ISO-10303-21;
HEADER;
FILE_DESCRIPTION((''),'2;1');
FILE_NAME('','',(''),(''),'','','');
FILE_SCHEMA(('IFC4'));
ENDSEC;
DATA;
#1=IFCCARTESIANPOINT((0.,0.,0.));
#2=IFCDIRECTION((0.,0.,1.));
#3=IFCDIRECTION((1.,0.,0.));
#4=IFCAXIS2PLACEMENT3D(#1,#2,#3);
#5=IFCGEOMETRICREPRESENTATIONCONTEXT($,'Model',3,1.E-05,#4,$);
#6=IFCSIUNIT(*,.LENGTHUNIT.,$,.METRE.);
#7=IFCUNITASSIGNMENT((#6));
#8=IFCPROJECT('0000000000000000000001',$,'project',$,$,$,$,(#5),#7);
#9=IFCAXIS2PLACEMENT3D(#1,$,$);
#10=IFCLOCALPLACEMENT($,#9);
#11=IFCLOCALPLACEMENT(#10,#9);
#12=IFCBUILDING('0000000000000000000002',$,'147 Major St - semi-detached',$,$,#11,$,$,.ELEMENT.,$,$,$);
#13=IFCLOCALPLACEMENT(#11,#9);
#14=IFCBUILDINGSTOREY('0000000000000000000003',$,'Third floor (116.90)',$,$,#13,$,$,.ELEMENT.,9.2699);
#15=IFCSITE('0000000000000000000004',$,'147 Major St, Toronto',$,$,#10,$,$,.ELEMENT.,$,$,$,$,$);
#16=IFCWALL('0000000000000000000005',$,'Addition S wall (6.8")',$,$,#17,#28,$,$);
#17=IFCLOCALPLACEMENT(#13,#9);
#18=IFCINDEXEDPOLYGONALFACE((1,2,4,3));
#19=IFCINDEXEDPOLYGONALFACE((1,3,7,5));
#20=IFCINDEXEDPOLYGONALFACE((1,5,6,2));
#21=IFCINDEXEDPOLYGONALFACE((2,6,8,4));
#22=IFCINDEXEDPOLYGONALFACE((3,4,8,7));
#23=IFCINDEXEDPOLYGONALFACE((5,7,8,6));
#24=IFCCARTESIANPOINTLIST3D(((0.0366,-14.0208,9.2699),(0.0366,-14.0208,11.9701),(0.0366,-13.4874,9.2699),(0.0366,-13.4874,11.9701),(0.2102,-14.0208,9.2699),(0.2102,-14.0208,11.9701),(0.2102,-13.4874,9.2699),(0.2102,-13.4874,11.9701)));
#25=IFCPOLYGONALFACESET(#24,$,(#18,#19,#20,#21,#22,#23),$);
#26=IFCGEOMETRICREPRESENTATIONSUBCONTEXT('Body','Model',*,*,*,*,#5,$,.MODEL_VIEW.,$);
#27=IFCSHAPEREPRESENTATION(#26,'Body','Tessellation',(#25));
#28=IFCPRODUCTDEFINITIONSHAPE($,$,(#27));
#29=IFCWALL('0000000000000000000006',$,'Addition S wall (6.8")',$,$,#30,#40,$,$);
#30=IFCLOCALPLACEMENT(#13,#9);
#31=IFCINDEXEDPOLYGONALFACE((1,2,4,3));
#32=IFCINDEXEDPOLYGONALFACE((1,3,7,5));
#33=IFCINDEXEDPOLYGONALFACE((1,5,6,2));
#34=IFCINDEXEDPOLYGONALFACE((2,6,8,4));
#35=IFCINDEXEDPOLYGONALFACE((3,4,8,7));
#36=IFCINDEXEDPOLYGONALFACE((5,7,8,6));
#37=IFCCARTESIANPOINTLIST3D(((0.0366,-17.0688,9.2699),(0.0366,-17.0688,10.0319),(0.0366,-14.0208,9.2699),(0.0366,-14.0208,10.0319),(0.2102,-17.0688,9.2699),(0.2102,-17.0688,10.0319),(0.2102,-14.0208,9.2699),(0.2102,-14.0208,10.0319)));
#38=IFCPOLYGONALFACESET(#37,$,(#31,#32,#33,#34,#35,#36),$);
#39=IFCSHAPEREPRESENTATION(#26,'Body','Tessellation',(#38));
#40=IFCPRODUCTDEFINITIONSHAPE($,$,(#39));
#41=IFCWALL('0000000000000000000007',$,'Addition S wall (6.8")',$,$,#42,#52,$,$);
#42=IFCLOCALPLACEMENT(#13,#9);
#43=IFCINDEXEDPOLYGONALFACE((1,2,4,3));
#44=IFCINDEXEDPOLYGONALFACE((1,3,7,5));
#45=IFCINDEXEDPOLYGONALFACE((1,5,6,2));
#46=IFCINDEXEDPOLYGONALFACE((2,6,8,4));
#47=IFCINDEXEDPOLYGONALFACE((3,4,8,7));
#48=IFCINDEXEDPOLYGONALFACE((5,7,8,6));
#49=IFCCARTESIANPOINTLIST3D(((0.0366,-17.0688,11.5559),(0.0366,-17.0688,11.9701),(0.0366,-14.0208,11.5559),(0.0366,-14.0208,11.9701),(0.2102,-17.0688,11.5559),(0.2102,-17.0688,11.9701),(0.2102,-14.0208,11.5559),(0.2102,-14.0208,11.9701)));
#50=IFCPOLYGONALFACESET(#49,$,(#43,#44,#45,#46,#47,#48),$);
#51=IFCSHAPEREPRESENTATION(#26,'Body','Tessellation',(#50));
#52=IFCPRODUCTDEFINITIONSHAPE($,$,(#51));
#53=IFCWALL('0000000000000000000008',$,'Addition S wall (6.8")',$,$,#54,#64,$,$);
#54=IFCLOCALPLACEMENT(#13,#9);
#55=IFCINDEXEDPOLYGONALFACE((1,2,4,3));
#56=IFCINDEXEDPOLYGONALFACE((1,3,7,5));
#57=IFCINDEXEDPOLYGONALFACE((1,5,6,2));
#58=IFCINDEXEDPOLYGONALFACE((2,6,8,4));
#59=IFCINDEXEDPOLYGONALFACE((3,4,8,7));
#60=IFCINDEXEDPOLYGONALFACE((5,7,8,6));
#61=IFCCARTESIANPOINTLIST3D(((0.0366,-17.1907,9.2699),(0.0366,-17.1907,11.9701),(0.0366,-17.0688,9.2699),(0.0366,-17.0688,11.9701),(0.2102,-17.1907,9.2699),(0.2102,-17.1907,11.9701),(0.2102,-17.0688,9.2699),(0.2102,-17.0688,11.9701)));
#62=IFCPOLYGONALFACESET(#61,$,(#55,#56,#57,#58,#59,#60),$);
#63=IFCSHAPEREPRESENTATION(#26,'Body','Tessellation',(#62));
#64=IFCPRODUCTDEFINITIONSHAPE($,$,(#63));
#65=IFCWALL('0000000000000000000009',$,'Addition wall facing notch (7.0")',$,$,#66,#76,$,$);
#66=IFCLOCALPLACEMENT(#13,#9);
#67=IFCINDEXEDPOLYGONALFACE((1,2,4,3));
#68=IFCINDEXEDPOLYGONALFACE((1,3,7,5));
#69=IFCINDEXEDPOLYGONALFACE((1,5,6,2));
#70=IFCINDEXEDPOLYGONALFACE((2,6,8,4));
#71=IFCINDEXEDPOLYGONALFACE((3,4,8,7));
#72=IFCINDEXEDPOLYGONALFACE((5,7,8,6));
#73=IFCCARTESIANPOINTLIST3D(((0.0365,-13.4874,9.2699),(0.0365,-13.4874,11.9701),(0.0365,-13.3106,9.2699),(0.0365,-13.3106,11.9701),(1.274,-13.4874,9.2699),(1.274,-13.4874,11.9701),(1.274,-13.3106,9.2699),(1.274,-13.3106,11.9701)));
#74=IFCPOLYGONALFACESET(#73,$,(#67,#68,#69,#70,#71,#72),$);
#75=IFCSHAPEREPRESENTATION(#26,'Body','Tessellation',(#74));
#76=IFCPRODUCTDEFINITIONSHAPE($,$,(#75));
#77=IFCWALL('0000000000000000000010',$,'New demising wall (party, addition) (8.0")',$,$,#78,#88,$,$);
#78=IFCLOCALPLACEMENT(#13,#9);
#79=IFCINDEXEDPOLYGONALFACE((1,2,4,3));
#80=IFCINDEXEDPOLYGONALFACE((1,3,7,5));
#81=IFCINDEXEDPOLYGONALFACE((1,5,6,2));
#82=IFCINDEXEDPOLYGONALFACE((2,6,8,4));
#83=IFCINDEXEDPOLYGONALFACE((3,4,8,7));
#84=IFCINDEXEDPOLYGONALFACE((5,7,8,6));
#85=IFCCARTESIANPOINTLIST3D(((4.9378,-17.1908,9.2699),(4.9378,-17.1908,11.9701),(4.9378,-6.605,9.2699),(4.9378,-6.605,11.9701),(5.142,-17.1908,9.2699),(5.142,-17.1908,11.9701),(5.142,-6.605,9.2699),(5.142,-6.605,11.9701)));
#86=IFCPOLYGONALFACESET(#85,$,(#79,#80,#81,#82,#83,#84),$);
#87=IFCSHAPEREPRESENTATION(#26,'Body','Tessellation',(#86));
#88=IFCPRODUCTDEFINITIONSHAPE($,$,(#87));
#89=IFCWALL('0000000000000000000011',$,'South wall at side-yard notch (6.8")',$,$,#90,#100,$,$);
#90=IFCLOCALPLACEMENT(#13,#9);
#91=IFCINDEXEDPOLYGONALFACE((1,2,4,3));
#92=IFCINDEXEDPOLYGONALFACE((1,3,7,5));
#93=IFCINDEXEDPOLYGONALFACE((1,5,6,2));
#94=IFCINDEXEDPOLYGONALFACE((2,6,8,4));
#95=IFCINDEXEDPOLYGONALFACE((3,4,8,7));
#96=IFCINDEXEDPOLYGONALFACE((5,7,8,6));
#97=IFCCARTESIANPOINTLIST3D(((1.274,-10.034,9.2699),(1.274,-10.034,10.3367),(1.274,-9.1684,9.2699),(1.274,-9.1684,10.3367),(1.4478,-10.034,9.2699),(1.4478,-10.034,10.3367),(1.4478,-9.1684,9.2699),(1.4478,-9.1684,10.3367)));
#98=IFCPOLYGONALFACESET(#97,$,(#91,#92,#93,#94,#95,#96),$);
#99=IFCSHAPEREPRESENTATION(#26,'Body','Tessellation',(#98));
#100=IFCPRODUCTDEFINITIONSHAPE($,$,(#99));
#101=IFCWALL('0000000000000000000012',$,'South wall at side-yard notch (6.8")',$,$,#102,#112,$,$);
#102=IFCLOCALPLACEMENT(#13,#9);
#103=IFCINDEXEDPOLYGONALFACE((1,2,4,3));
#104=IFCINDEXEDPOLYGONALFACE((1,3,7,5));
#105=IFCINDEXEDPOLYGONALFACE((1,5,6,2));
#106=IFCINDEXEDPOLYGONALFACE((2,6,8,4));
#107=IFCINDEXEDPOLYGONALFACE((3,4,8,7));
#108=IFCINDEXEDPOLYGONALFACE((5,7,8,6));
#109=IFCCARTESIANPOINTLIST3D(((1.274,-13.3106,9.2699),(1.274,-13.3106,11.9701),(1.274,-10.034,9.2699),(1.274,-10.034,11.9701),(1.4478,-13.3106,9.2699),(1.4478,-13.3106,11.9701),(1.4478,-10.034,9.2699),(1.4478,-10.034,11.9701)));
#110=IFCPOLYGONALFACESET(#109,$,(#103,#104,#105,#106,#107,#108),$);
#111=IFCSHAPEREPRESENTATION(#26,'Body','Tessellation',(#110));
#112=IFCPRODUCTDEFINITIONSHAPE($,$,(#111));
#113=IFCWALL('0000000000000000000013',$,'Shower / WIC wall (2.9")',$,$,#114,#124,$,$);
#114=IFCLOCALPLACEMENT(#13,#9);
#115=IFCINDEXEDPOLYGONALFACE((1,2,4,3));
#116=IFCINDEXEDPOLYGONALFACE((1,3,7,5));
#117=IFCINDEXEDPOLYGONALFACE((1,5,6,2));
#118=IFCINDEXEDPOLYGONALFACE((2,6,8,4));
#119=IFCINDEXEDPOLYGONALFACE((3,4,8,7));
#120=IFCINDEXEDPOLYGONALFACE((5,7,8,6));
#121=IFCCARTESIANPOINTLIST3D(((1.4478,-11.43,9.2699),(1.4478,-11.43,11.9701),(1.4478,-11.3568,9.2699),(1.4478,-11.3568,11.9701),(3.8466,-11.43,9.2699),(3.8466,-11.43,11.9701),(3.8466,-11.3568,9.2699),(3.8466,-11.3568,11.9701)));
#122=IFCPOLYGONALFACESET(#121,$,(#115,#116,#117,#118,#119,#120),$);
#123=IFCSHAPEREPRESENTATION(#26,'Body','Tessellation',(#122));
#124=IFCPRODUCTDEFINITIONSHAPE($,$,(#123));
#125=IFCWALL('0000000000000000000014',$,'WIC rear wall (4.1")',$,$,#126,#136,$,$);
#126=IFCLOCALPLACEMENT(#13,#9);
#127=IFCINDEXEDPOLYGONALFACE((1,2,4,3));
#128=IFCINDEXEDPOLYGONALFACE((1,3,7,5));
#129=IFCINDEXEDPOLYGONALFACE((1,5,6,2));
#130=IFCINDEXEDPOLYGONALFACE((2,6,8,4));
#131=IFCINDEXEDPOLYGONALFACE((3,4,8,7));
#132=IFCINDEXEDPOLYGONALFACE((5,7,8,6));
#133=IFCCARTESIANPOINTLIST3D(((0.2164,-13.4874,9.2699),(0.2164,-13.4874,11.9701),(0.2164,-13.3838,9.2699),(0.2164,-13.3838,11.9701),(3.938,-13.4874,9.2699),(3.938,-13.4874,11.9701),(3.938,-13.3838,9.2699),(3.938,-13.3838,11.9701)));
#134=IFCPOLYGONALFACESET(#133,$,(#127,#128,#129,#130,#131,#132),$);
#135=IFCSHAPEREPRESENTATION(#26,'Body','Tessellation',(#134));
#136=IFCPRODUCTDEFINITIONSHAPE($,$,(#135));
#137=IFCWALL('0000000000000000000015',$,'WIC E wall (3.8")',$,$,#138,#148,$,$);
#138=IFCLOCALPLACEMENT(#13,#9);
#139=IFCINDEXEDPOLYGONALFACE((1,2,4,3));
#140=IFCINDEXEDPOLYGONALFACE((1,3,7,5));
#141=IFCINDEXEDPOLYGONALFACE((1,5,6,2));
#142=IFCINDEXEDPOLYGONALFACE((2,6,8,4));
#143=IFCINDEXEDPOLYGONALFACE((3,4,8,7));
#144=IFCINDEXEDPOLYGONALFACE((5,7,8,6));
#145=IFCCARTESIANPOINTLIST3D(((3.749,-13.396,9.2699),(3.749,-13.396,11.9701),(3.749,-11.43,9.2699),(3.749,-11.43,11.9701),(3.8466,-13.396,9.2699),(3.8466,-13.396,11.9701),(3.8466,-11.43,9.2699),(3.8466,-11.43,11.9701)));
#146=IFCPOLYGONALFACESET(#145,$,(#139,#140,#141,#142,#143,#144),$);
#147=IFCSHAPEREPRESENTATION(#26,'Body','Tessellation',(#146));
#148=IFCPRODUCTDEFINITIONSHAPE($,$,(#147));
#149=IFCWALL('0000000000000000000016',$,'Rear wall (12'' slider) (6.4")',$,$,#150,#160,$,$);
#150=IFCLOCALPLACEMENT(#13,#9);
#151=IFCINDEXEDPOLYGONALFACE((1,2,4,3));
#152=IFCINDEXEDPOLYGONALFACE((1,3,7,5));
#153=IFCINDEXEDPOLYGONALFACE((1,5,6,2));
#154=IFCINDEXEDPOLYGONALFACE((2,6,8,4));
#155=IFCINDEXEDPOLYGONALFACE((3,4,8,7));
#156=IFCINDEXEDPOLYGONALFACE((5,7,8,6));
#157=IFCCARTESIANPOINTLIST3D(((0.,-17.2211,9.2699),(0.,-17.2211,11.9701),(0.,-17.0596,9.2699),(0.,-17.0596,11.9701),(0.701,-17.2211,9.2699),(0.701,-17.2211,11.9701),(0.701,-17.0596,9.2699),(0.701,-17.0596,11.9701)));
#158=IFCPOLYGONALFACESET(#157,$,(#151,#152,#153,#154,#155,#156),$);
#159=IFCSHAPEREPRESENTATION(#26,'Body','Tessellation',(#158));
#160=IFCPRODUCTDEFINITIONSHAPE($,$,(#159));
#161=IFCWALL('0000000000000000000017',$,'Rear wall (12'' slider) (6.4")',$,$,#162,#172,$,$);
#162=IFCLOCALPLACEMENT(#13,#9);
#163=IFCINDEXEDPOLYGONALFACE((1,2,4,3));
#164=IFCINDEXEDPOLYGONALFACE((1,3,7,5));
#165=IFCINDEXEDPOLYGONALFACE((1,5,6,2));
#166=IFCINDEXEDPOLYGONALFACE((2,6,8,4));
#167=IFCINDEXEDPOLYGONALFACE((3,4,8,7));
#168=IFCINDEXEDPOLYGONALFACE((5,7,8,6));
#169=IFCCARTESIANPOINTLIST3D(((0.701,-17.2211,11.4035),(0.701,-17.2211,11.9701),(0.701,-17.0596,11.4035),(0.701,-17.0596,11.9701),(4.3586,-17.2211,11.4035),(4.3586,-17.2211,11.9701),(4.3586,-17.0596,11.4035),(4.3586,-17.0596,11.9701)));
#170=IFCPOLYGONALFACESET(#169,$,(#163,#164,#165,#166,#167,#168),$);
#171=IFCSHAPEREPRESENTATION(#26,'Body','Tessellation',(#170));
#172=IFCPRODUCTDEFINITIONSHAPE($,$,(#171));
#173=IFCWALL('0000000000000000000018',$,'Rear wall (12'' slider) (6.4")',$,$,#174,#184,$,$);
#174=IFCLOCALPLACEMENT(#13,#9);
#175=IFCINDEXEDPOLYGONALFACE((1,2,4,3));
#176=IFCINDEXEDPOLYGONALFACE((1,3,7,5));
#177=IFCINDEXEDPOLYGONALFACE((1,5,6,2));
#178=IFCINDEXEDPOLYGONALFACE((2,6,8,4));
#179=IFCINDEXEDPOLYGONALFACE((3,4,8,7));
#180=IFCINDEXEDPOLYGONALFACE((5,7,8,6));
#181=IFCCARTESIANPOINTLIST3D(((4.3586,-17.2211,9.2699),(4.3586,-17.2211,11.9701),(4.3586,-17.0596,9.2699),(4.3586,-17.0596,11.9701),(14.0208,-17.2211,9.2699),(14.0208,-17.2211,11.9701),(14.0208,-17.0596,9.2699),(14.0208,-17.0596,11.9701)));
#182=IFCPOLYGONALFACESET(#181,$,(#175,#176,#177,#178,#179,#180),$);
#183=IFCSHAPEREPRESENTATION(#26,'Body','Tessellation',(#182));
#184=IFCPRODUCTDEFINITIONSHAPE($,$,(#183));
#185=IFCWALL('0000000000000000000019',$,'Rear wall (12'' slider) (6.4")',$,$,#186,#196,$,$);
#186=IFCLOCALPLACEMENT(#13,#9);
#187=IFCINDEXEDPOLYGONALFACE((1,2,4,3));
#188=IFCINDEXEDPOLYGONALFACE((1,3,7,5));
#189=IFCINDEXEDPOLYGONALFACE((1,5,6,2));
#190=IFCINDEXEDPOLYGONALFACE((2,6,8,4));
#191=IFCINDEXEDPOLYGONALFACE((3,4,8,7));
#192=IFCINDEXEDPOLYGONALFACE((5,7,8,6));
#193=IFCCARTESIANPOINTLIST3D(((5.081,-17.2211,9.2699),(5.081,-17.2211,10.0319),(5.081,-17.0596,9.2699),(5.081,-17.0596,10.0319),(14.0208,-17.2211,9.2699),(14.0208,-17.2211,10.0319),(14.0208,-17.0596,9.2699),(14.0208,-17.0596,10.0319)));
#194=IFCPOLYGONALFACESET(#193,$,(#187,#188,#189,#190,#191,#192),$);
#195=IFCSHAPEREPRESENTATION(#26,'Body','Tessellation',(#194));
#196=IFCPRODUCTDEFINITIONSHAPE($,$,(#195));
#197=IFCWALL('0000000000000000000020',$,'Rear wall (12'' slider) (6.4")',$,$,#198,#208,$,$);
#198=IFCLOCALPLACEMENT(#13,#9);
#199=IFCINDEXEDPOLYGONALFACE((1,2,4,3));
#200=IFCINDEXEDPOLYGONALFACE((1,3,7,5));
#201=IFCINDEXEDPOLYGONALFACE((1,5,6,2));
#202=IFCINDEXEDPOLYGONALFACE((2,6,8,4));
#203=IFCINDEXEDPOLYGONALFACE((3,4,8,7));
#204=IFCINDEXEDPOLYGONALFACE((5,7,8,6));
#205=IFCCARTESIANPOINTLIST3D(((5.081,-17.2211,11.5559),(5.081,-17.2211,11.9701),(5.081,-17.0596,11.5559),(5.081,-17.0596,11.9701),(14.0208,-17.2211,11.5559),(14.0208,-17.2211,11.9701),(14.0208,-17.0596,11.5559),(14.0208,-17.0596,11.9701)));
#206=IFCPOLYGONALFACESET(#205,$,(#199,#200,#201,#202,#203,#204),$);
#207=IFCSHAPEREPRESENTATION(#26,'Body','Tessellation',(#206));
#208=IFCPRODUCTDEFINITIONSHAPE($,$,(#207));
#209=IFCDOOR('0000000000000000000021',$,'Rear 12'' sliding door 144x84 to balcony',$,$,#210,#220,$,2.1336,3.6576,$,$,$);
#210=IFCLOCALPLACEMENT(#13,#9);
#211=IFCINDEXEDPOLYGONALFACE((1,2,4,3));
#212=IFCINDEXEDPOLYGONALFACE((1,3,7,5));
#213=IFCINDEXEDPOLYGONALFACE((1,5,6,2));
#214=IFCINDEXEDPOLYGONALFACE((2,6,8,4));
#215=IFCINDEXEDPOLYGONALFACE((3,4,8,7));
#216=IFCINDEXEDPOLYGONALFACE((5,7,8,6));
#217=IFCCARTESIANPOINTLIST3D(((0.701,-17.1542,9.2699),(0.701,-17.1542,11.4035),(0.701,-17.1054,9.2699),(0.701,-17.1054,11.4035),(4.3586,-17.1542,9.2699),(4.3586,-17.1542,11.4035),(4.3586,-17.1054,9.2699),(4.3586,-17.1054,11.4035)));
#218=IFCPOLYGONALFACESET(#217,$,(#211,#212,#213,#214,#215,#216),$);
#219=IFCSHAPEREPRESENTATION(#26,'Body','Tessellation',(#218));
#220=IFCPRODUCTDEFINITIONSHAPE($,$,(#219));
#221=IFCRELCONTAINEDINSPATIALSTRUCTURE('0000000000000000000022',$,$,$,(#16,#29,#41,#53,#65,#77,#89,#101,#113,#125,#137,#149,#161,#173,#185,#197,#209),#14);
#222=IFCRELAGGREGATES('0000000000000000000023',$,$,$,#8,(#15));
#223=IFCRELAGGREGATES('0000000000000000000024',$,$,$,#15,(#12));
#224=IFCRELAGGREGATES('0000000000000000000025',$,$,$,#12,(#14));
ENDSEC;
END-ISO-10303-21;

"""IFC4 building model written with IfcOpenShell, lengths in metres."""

from ifc_helpers import new_model, si_unit, frame, origin, origin_with_axes, place, context, subcontext, project, spatial, rectangle, extrude, element, save


model = new_model("IFC4")

# Units and contexts
model_context = context("Model", 3, precision=1e-05, world=origin_with_axes())
body_context = subcontext(model_context, "Body", "Model", "MODEL_VIEW")
ifc_project = project(units=[si_unit("LENGTHUNIT", "METRE")], contexts=[model_context])

# Site, building, storey
site_placement = place(None, origin())
site = spatial("IfcSite", under=ifc_project, at=site_placement, Name="147 Major St, Toronto", CompositionType="ELEMENT")
building_placement = place(site_placement, origin())
building = spatial("IfcBuilding", under=site, at=building_placement, Name="147 Major St - semi-detached", CompositionType="ELEMENT")
storey_placement = place(building_placement, origin())
storey = spatial("IfcBuildingStorey", under=building, at=storey_placement, Name="Third floor (116.90)", CompositionType="ELEMENT", Elevation=9.2699)

# Walls
wall_1_placement = place(storey_placement, frame((0.1234, -13.7541, 9.2699)))
element("IfcWall", 1, at=wall_1_placement, inside=storey, Name="Addition S wall (6.8\")", context=body_context, shape_type="SweptSolid", body=[
    extrude(rectangle(XDim=0.1737, YDim=0.5334), origin_with_axes(), (0.0, 0.0, 1.0), 2.7002),
])
wall_2_placement = place(storey_placement, frame((0.1234, -15.5448, 9.2699)))
element("IfcWall", 2, at=wall_2_placement, inside=storey, Name="Addition S wall (6.8\")", context=body_context, shape_type="SweptSolid", body=[
    extrude(rectangle(XDim=0.1737, YDim=3.048), origin_with_axes(), (0.0, 0.0, 1.0), 0.762),
])
wall_3_placement = place(storey_placement, frame((0.1234, -15.5448, 11.5559)))
element("IfcWall", 3, at=wall_3_placement, inside=storey, Name="Addition S wall (6.8\")", context=body_context, shape_type="SweptSolid", body=[
    extrude(rectangle(XDim=0.1737, YDim=3.048), origin_with_axes(), (0.0, 0.0, 1.0), 0.4142),
])
wall_4_placement = place(storey_placement, frame((0.1234, -17.1298, 9.2699)))
element("IfcWall", 4, at=wall_4_placement, inside=storey, Name="Addition S wall (6.8\")", context=body_context, shape_type="SweptSolid", body=[
    extrude(rectangle(XDim=0.1737, YDim=0.1219), origin_with_axes(), (0.0, 0.0, 1.0), 2.7002),
])
wall_5_placement = place(storey_placement, frame((0.6553, -13.399, 9.2699)))
element("IfcWall", 5, at=wall_5_placement, inside=storey, Name="Addition wall facing notch (7.0\")", context=body_context, shape_type="SweptSolid", body=[
    extrude(rectangle(XDim=1.2375, YDim=0.1768), origin_with_axes(), (0.0, 0.0, 1.0), 2.7002),
])
wall_6_placement = place(storey_placement, frame((5.0399, -11.8979, 9.2699)))
element("IfcWall", 6, at=wall_6_placement, inside=storey, Name="New demising wall (party, addition) (8.0\")", context=body_context, shape_type="SweptSolid", body=[
    extrude(rectangle(XDim=0.2042, YDim=10.5857), origin_with_axes(), (0.0, 0.0, 1.0), 2.7002),
])
wall_7_placement = place(storey_placement, frame((1.3609, -9.6012, 9.2699)))
element("IfcWall", 7, at=wall_7_placement, inside=storey, Name="South wall at side-yard notch (6.8\")", context=body_context, shape_type="SweptSolid", body=[
    extrude(rectangle(XDim=0.1737, YDim=0.8656), origin_with_axes(), (0.0, 0.0, 1.0), 1.0668),
])
wall_8_placement = place(storey_placement, frame((1.3609, -11.6723, 9.2699)))
element("IfcWall", 8, at=wall_8_placement, inside=storey, Name="South wall at side-yard notch (6.8\")", context=body_context, shape_type="SweptSolid", body=[
    extrude(rectangle(XDim=0.1737, YDim=3.2766), origin_with_axes(), (0.0, 0.0, 1.0), 2.7002),
])
wall_9_placement = place(storey_placement, frame((2.6472, -11.3934, 9.2699)))
element("IfcWall", 9, at=wall_9_placement, inside=storey, Name="Shower / WIC wall (2.9\")", context=body_context, shape_type="SweptSolid", body=[
    extrude(rectangle(XDim=2.3988, YDim=0.0732), origin_with_axes(), (0.0, 0.0, 1.0), 2.7002),
])
wall_10_placement = place(storey_placement, frame((2.0772, -13.4356, 9.2699)))
element("IfcWall", 10, at=wall_10_placement, inside=storey, Name="WIC rear wall (4.1\")", context=body_context, shape_type="SweptSolid", body=[
    extrude(rectangle(XDim=3.7216, YDim=0.1036), origin_with_axes(), (0.0, 0.0, 1.0), 2.7002),
])
wall_11_placement = place(storey_placement, frame((3.7978, -12.413, 9.2699)))
element("IfcWall", 11, at=wall_11_placement, inside=storey, Name="WIC E wall (3.8\")", context=body_context, shape_type="SweptSolid", body=[
    extrude(rectangle(XDim=0.0975, YDim=1.966), origin_with_axes(), (0.0, 0.0, 1.0), 2.7002),
])
wall_12_placement = place(storey_placement, frame((0.3505, -17.1404, 9.2699)))
element("IfcWall", 12, at=wall_12_placement, inside=storey, Name="Rear wall (12' slider) (6.4\")", context=body_context, shape_type="SweptSolid", body=[
    extrude(rectangle(XDim=0.701, YDim=0.1615), origin_with_axes(), (0.0, 0.0, 1.0), 2.7002),
])
wall_13_placement = place(storey_placement, frame((2.5298, -17.1404, 11.4035)))
element("IfcWall", 13, at=wall_13_placement, inside=storey, Name="Rear wall (12' slider) (6.4\")", context=body_context, shape_type="SweptSolid", body=[
    extrude(rectangle(XDim=3.6576, YDim=0.1615), origin_with_axes(), (0.0, 0.0, 1.0), 0.5666),
])
wall_14_placement = place(storey_placement, frame((9.1897, -17.1404, 9.2699)))
element("IfcWall", 14, at=wall_14_placement, inside=storey, Name="Rear wall (12' slider) (6.4\")", context=body_context, shape_type="SweptSolid", body=[
    extrude(rectangle(XDim=9.6622, YDim=0.1615), origin_with_axes(), (0.0, 0.0, 1.0), 2.7002),
])
wall_15_placement = place(storey_placement, frame((9.5509, -17.1404, 9.2699)))
element("IfcWall", 15, at=wall_15_placement, inside=storey, Name="Rear wall (12' slider) (6.4\")", context=body_context, shape_type="SweptSolid", body=[
    extrude(rectangle(XDim=8.9398, YDim=0.1615), origin_with_axes(), (0.0, 0.0, 1.0), 0.762),
])
wall_16_placement = place(storey_placement, frame((9.5509, -17.1404, 11.5559)))
element("IfcWall", 16, at=wall_16_placement, inside=storey, Name="Rear wall (12' slider) (6.4\")", context=body_context, shape_type="SweptSolid", body=[
    extrude(rectangle(XDim=8.9398, YDim=0.1615), origin_with_axes(), (0.0, 0.0, 1.0), 0.4142),
])

# Door
door_placement = place(storey_placement, frame((2.5298, -17.1298, 9.2699)))
element("IfcDoor", 17, at=door_placement, inside=storey, Name="Rear 12' sliding door 144x84 to balcony", OverallHeight=2.1336, OverallWidth=3.6576, context=body_context, shape_type="SweptSolid", body=[
    extrude(rectangle(XDim=3.6576, YDim=0.0488), origin_with_axes(), (0.0, 0.0, 1.0), 2.1336),
])

save(model, "model.ifc")
